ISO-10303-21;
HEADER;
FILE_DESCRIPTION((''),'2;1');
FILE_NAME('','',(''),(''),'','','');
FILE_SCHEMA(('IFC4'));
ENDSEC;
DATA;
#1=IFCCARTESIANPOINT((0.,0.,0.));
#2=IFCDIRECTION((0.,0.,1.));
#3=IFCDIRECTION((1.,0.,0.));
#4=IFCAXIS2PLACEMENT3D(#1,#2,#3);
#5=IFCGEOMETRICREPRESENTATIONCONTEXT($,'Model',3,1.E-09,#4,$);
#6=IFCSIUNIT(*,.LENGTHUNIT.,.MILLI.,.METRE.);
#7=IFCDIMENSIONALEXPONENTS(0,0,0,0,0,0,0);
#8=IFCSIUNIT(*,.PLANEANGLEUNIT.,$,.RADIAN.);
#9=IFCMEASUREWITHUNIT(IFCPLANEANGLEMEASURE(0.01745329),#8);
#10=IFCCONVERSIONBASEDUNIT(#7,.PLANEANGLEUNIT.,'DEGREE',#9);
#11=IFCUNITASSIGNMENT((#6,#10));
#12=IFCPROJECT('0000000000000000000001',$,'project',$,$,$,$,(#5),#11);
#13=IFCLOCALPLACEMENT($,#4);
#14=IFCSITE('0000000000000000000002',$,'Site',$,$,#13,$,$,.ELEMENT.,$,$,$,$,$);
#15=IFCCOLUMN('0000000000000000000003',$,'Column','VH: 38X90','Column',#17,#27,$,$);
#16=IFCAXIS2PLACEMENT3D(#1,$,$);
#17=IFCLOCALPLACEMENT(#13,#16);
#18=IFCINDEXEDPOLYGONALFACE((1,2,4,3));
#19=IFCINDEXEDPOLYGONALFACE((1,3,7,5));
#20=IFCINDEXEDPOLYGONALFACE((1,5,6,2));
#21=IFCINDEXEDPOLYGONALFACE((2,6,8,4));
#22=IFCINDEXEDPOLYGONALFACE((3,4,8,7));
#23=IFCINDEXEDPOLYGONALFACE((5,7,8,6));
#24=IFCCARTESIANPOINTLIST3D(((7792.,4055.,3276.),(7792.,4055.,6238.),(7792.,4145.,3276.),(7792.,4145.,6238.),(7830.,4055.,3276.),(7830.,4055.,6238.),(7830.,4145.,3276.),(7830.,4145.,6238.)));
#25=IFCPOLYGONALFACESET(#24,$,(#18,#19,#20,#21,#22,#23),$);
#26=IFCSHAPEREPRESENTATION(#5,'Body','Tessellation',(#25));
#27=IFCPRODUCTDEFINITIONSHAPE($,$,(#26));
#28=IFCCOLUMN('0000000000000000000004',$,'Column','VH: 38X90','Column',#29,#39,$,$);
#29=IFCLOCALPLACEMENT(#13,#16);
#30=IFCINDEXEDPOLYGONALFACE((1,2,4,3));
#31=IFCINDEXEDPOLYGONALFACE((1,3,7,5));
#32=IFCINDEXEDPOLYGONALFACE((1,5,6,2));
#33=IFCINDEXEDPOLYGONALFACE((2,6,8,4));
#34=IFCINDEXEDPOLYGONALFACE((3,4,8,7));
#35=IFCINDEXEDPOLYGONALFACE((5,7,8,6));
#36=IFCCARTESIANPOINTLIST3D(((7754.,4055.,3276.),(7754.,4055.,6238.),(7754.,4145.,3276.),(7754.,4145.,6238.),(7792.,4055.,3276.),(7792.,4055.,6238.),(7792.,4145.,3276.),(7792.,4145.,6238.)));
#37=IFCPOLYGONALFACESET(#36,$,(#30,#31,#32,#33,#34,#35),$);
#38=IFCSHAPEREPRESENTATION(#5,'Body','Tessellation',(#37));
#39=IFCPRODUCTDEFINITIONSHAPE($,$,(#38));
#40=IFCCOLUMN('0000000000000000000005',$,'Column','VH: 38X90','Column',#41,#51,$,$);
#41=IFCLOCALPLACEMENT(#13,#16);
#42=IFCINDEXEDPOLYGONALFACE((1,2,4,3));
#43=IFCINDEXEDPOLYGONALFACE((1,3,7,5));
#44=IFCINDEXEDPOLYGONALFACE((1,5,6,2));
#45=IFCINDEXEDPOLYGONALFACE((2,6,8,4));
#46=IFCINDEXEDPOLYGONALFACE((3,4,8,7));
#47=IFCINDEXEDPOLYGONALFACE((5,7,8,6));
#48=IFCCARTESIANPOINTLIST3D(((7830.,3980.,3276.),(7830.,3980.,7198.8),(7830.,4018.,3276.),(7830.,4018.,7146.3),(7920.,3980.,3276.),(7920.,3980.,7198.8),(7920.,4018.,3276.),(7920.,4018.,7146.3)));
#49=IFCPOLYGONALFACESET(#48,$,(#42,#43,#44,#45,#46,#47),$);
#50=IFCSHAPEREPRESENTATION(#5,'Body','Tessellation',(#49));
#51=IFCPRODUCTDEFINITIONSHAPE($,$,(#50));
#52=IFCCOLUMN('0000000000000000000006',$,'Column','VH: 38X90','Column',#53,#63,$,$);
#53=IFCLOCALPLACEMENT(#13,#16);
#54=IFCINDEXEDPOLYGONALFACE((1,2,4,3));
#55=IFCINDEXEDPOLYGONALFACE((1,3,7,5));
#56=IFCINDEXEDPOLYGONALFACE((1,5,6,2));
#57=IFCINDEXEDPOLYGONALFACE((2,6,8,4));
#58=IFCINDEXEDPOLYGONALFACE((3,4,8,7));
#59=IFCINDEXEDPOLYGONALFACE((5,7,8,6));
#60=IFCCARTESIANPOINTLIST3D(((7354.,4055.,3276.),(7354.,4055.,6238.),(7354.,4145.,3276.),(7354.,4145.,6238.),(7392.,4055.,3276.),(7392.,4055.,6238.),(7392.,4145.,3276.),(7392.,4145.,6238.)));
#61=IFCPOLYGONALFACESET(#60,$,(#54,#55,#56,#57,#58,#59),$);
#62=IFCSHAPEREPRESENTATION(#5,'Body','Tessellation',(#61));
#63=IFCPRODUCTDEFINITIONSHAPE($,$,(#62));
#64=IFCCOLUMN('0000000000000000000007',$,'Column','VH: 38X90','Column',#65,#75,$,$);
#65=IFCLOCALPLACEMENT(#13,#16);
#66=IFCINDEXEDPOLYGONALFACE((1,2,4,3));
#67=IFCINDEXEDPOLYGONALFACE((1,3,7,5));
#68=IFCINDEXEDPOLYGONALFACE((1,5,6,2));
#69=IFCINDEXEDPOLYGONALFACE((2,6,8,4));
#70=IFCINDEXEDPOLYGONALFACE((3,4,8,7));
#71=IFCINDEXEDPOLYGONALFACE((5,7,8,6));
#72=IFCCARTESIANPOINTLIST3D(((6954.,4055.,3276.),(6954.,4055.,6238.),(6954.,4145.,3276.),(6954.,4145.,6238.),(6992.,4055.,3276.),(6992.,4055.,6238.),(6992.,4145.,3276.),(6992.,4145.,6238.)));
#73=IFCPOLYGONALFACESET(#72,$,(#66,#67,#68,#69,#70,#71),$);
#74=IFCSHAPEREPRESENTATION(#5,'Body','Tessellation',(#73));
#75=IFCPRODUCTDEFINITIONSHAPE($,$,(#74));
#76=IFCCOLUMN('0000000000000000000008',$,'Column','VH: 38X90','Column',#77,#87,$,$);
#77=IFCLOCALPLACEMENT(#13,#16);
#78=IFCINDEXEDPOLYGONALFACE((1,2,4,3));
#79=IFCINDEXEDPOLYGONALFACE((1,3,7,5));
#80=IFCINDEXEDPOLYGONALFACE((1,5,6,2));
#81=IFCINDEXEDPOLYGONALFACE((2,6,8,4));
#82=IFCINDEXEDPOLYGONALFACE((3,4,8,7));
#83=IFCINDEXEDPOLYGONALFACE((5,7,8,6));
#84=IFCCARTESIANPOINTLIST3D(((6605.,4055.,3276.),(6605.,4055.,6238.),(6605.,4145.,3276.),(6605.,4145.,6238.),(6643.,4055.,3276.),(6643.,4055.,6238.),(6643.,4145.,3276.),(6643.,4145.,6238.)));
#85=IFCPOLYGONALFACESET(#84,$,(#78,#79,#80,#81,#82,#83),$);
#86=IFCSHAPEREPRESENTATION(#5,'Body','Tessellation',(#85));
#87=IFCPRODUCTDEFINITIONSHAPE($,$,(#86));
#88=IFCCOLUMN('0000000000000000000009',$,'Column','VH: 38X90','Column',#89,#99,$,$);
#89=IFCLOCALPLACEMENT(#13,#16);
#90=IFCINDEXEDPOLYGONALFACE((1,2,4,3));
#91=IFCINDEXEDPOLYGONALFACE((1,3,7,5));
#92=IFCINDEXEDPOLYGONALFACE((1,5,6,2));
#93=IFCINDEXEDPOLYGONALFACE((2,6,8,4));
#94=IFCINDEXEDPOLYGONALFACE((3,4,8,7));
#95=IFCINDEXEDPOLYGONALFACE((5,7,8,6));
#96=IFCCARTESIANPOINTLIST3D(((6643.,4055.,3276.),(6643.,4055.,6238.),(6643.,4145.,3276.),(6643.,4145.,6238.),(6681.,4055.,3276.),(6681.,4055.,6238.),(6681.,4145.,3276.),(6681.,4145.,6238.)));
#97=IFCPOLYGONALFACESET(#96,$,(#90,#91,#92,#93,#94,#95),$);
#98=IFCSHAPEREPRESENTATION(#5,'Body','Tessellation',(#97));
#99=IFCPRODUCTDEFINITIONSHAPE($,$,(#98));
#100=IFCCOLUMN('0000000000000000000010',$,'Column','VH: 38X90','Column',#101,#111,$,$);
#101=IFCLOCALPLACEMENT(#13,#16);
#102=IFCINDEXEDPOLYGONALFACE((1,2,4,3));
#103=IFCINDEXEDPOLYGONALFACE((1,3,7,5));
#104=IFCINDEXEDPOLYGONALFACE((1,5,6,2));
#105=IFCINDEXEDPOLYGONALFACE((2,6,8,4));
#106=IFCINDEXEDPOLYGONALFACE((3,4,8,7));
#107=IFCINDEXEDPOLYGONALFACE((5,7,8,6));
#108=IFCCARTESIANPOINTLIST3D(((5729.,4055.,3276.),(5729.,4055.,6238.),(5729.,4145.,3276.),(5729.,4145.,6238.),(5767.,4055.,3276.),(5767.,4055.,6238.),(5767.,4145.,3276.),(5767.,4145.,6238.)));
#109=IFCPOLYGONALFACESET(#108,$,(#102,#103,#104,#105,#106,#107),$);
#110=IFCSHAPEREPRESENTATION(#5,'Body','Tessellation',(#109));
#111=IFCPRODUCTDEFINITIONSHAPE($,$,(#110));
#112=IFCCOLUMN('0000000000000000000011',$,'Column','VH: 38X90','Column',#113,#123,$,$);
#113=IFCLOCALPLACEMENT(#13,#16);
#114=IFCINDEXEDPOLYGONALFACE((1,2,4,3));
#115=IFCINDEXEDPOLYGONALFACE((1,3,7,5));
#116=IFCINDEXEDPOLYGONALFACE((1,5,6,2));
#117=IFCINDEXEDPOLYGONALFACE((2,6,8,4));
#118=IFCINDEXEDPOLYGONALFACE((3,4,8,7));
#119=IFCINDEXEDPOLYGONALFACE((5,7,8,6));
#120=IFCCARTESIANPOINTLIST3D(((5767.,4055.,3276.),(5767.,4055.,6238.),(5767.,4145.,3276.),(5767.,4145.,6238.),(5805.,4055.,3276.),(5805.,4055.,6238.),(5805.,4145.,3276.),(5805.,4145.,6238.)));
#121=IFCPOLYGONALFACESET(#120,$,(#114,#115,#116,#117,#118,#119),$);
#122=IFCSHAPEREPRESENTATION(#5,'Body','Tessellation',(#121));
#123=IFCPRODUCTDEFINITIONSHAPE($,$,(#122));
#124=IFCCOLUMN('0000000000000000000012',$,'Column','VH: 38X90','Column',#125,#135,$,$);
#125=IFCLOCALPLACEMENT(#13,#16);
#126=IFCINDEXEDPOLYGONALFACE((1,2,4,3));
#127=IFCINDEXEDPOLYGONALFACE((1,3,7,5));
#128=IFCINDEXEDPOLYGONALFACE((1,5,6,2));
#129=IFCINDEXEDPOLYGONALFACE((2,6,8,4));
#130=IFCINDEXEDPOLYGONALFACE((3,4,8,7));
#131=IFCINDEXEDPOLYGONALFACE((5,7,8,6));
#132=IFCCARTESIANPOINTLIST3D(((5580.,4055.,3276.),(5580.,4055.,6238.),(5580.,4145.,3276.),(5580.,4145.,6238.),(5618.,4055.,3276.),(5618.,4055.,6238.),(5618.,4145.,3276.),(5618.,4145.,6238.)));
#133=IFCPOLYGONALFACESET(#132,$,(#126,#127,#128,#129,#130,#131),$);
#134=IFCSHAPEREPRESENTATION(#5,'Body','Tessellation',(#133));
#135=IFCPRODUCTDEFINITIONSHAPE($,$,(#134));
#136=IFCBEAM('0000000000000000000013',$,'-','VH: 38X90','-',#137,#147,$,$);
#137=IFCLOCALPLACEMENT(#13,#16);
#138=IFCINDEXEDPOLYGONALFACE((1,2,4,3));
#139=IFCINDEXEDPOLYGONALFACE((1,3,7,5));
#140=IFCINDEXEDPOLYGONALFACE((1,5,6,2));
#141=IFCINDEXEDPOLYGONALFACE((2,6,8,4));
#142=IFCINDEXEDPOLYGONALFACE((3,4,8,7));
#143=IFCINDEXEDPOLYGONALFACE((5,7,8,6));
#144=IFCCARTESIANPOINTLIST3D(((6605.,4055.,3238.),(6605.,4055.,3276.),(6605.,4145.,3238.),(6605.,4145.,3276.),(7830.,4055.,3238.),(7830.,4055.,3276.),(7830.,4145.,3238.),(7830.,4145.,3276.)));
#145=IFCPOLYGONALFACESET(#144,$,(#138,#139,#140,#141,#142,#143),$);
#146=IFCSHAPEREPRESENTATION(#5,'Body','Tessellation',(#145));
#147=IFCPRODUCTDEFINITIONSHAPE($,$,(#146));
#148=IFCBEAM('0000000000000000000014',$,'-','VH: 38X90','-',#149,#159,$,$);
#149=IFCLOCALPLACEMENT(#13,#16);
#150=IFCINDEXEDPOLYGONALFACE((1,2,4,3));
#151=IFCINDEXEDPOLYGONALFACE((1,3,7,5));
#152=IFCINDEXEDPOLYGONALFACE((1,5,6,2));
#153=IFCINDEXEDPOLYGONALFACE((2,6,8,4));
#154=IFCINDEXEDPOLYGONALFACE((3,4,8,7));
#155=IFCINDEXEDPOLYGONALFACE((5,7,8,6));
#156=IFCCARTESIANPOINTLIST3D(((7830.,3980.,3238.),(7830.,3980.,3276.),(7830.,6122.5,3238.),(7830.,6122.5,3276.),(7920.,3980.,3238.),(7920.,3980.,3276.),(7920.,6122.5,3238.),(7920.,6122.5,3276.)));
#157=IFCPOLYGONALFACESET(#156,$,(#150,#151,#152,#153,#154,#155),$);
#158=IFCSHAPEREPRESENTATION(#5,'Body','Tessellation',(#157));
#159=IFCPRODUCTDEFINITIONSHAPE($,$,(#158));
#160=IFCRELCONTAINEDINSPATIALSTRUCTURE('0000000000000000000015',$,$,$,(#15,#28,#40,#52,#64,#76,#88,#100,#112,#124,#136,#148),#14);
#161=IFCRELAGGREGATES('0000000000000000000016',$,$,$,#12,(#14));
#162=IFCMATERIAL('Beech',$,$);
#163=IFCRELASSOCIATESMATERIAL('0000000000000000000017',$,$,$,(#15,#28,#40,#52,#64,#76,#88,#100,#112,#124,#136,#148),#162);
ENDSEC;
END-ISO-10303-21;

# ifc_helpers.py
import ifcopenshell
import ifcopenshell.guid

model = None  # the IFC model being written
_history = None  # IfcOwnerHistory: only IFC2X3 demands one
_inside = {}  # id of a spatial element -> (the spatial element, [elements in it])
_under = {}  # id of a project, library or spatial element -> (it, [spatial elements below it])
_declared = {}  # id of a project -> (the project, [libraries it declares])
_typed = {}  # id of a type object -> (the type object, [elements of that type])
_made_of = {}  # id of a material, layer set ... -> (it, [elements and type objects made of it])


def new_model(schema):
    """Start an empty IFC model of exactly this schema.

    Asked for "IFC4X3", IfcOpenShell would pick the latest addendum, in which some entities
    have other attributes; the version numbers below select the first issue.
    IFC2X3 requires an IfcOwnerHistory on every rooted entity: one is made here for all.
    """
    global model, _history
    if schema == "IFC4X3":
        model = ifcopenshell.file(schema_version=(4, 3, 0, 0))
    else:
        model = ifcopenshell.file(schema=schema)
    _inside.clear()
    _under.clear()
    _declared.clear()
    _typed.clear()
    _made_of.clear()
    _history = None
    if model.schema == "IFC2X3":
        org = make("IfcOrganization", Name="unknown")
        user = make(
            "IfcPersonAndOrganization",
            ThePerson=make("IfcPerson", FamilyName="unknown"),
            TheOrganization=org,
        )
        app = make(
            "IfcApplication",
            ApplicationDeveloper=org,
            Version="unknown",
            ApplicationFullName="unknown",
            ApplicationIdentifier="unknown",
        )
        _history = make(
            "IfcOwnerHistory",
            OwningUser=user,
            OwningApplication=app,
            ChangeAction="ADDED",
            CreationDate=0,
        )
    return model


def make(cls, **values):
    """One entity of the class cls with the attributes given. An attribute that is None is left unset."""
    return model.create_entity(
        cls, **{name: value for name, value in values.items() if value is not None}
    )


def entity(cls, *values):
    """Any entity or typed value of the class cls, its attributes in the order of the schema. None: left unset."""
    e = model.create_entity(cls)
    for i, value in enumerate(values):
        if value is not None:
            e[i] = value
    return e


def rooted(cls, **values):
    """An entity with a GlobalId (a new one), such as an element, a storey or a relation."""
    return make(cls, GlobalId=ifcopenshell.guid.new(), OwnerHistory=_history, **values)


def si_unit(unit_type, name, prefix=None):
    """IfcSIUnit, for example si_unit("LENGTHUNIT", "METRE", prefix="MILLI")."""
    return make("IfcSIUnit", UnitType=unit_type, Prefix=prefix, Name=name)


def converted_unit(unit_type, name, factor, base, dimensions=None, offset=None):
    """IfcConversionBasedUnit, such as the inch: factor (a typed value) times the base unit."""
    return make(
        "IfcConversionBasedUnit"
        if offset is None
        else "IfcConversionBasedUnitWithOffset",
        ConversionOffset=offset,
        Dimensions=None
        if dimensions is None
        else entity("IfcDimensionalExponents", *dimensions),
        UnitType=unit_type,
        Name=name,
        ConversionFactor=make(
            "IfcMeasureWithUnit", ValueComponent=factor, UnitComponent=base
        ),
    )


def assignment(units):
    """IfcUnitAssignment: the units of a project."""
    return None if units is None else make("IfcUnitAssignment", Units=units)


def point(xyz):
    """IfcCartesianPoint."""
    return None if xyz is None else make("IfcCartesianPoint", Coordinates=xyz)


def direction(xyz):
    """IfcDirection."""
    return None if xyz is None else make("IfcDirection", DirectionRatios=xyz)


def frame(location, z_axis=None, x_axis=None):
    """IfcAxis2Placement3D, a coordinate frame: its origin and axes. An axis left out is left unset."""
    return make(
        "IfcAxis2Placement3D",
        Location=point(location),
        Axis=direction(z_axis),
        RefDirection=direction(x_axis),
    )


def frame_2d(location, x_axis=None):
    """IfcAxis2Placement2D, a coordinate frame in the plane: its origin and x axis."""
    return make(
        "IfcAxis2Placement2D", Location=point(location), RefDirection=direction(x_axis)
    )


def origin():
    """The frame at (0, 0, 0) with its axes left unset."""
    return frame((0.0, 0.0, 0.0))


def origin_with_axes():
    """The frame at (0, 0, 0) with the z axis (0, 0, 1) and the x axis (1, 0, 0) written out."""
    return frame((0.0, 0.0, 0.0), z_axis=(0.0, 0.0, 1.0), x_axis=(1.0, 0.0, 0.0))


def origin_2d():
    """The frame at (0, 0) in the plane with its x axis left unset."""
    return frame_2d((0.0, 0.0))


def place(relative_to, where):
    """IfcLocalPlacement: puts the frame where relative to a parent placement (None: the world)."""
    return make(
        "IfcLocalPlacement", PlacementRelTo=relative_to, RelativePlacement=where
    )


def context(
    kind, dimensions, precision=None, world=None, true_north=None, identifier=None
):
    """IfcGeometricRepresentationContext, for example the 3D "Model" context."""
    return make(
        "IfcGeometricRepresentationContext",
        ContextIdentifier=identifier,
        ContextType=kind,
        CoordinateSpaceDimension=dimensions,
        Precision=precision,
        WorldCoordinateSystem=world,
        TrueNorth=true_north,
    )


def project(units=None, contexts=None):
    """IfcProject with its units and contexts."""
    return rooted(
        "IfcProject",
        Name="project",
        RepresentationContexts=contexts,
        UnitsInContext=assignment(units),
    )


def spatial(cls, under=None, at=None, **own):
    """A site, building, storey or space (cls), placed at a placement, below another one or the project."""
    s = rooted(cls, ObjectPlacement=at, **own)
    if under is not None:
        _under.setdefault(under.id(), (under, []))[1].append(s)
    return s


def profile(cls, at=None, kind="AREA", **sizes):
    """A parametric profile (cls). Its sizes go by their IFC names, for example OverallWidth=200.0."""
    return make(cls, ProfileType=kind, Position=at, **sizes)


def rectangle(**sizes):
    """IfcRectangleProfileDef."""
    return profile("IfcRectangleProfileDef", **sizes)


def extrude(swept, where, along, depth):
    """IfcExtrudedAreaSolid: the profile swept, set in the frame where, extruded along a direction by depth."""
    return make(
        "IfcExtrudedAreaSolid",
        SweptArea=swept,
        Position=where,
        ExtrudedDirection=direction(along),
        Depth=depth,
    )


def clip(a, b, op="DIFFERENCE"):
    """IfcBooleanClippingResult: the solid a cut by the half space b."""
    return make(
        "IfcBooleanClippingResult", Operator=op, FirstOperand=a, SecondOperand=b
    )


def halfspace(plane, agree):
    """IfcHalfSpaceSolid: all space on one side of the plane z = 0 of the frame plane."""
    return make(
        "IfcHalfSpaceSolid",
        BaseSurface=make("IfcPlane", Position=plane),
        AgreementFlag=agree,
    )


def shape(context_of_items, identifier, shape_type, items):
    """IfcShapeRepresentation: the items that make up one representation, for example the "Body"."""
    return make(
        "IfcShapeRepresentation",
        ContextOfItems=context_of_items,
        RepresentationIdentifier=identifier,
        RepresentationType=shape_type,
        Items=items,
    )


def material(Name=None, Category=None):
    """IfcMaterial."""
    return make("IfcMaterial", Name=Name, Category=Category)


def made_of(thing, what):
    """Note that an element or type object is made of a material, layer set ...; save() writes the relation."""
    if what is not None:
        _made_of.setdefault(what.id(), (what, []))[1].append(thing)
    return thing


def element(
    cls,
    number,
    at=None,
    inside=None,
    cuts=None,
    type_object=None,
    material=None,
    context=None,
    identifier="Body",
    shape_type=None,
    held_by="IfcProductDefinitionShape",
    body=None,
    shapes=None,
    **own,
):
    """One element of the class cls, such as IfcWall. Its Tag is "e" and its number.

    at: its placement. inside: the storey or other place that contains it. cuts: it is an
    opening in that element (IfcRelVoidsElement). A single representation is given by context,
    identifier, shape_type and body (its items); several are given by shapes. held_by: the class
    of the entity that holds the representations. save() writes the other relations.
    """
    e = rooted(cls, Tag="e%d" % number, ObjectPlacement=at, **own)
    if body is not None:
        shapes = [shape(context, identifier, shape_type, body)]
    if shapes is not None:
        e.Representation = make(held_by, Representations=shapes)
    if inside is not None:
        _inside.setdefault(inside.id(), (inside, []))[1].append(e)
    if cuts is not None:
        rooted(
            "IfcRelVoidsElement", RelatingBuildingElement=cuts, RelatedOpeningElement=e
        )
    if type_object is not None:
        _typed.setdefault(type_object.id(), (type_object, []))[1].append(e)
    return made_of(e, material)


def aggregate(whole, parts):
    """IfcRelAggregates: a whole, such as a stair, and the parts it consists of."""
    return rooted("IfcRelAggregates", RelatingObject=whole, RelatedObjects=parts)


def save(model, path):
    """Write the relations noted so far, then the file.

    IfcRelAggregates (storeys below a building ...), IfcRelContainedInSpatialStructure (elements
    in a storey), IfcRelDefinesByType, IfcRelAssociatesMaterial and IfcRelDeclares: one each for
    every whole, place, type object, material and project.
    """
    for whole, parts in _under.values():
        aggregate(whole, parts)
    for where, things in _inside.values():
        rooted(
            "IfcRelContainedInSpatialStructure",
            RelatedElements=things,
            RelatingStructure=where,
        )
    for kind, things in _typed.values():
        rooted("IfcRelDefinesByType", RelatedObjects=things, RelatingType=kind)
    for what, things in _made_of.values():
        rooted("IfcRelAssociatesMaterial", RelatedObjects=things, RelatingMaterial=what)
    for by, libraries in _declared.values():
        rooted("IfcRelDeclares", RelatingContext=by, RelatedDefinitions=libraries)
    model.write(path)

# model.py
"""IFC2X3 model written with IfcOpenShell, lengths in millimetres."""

from ifc_helpers import new_model, entity, si_unit, converted_unit, frame, origin, origin_with_axes, origin_2d, place, context, project, spatial, rectangle, extrude, clip, halfspace, material, element, save


model = new_model("IFC2X3")

# Units and contexts
model_context = context("Model", 3, precision=1e-09, world=origin_with_axes())
ifc_project = project(units=[si_unit("LENGTHUNIT", "METRE", prefix="MILLI"), converted_unit("PLANEANGLEUNIT", "DEGREE", entity("IfcPlaneAngleMeasure", 0.01745329), si_unit("PLANEANGLEUNIT", "RADIAN"), dimensions=[0, 0, 0, 0, 0, 0, 0])], contexts=[model_context])

# Site
site_placement = place(None, origin_with_axes())
site = spatial("IfcSite", under=ifc_project, at=site_placement, Name="Site", CompositionType="ELEMENT")

# Columns
ifc_material = material(Name="Beech")
for number, where, z_axis, x_axis, name in (
    (1, (7811.0, 4100.0, 3276.0), (0.0, 0.0, -1.0), (-1.0, 0.0, 0.0), "Column"),
    (2, (7773.0, 4100.0, 3276.0), (0.0, 0.0, -1.0), (-1.0, 0.0, 0.0), "Column"),
):
    element("IfcColumn", number, at=place(None, frame(where, z_axis=z_axis, x_axis=x_axis)), inside=site, material=ifc_material, Name=name, Description="VH: 38X90", ObjectType="Column", context=model_context, shape_type="SweptSolid", body=[
        extrude(rectangle(XDim=38.0, YDim=90.0, at=origin_2d()), origin(), (0.0, 0.0, -1.0), 2962.0),
    ])
column_1_placement = place(None, frame((7875.0, 3999.0, 3276.0), z_axis=(0.0, 0.0, -1.0), x_axis=(0.0, -1.0, 0.0)))
element("IfcColumn", 3, at=column_1_placement, inside=site, material=ifc_material, Name="Column", Description="VH: 38X90", ObjectType="Column", context=model_context, shape_type="Clipping", body=[
    clip(extrude(rectangle(XDim=38.0, YDim=90.0, at=origin_2d()), origin(), (0.0, 0.0, -1.0), 3979.9), halfspace(frame((-2032.2, 7875.0, -1088.2), z_axis=(0.810145, 0.0, 0.58623), x_axis=(0.0, -1.0, 0.0)), True)),
])
for number, where, z_axis, x_axis, name in (
    (4, (7373.0, 4100.0, 3276.0), (0.0, 0.0, -1.0), (-1.0, 0.0, 0.0), "Column"),
    (5, (6973.0, 4100.0, 3276.0), (0.0, 0.0, -1.0), (-1.0, 0.0, 0.0), "Column"),
    (6, (6624.0, 4100.0, 3276.0), (0.0, 0.0, -1.0), (-1.0, 0.0, 0.0), "Column"),
    (7, (6662.0, 4100.0, 3276.0), (0.0, 0.0, -1.0), (-1.0, 0.0, 0.0), "Column"),
    (8, (5748.0, 4100.0, 3276.0), (0.0, 0.0, -1.0), (-1.0, 0.0, 0.0), "Column"),
    (9, (5786.0, 4100.0, 3276.0), (0.0, 0.0, -1.0), (-1.0, 0.0, 0.0), "Column"),
    (10, (5599.0, 4100.0, 3276.0), (0.0, 0.0, -1.0), (-1.0, 0.0, 0.0), "Column"),
):
    element("IfcColumn", number, at=place(None, frame(where, z_axis=z_axis, x_axis=x_axis)), inside=site, material=ifc_material, Name=name, Description="VH: 38X90", ObjectType="Column", context=model_context, shape_type="SweptSolid", body=[
        extrude(rectangle(XDim=38.0, YDim=90.0, at=origin_2d()), origin(), (0.0, 0.0, -1.0), 2962.0),
    ])

# Beams
beam_1_placement = place(None, frame((6605.0, 4100.0, 3257.0), z_axis=(-1.0, 0.0, 0.0), x_axis=(0.0, 0.0, -1.0)))
element("IfcBeam", 11, at=beam_1_placement, inside=site, material=ifc_material, Name="-", Description="VH: 38X90", ObjectType="-", context=model_context, shape_type="SweptSolid", body=[
    extrude(rectangle(XDim=38.0, YDim=90.0, at=origin_2d()), origin(), (0.0, 0.0, -1.0), 1225.0),
])
beam_2_placement = place(None, frame((7875.0, 6122.5, 3257.0), z_axis=(0.0, 1.0, 0.0), x_axis=(0.0, 0.0, -1.0)))
element("IfcBeam", 12, at=beam_2_placement, inside=site, material=ifc_material, Name="-", Description="VH: 38X90", ObjectType="-", context=model_context, shape_type="SweptSolid", body=[
    extrude(rectangle(XDim=38.0, YDim=90.0, at=origin_2d()), origin(), (0.0, 0.0, -1.0), 2142.5),
])

save(model, "model.ifc")
